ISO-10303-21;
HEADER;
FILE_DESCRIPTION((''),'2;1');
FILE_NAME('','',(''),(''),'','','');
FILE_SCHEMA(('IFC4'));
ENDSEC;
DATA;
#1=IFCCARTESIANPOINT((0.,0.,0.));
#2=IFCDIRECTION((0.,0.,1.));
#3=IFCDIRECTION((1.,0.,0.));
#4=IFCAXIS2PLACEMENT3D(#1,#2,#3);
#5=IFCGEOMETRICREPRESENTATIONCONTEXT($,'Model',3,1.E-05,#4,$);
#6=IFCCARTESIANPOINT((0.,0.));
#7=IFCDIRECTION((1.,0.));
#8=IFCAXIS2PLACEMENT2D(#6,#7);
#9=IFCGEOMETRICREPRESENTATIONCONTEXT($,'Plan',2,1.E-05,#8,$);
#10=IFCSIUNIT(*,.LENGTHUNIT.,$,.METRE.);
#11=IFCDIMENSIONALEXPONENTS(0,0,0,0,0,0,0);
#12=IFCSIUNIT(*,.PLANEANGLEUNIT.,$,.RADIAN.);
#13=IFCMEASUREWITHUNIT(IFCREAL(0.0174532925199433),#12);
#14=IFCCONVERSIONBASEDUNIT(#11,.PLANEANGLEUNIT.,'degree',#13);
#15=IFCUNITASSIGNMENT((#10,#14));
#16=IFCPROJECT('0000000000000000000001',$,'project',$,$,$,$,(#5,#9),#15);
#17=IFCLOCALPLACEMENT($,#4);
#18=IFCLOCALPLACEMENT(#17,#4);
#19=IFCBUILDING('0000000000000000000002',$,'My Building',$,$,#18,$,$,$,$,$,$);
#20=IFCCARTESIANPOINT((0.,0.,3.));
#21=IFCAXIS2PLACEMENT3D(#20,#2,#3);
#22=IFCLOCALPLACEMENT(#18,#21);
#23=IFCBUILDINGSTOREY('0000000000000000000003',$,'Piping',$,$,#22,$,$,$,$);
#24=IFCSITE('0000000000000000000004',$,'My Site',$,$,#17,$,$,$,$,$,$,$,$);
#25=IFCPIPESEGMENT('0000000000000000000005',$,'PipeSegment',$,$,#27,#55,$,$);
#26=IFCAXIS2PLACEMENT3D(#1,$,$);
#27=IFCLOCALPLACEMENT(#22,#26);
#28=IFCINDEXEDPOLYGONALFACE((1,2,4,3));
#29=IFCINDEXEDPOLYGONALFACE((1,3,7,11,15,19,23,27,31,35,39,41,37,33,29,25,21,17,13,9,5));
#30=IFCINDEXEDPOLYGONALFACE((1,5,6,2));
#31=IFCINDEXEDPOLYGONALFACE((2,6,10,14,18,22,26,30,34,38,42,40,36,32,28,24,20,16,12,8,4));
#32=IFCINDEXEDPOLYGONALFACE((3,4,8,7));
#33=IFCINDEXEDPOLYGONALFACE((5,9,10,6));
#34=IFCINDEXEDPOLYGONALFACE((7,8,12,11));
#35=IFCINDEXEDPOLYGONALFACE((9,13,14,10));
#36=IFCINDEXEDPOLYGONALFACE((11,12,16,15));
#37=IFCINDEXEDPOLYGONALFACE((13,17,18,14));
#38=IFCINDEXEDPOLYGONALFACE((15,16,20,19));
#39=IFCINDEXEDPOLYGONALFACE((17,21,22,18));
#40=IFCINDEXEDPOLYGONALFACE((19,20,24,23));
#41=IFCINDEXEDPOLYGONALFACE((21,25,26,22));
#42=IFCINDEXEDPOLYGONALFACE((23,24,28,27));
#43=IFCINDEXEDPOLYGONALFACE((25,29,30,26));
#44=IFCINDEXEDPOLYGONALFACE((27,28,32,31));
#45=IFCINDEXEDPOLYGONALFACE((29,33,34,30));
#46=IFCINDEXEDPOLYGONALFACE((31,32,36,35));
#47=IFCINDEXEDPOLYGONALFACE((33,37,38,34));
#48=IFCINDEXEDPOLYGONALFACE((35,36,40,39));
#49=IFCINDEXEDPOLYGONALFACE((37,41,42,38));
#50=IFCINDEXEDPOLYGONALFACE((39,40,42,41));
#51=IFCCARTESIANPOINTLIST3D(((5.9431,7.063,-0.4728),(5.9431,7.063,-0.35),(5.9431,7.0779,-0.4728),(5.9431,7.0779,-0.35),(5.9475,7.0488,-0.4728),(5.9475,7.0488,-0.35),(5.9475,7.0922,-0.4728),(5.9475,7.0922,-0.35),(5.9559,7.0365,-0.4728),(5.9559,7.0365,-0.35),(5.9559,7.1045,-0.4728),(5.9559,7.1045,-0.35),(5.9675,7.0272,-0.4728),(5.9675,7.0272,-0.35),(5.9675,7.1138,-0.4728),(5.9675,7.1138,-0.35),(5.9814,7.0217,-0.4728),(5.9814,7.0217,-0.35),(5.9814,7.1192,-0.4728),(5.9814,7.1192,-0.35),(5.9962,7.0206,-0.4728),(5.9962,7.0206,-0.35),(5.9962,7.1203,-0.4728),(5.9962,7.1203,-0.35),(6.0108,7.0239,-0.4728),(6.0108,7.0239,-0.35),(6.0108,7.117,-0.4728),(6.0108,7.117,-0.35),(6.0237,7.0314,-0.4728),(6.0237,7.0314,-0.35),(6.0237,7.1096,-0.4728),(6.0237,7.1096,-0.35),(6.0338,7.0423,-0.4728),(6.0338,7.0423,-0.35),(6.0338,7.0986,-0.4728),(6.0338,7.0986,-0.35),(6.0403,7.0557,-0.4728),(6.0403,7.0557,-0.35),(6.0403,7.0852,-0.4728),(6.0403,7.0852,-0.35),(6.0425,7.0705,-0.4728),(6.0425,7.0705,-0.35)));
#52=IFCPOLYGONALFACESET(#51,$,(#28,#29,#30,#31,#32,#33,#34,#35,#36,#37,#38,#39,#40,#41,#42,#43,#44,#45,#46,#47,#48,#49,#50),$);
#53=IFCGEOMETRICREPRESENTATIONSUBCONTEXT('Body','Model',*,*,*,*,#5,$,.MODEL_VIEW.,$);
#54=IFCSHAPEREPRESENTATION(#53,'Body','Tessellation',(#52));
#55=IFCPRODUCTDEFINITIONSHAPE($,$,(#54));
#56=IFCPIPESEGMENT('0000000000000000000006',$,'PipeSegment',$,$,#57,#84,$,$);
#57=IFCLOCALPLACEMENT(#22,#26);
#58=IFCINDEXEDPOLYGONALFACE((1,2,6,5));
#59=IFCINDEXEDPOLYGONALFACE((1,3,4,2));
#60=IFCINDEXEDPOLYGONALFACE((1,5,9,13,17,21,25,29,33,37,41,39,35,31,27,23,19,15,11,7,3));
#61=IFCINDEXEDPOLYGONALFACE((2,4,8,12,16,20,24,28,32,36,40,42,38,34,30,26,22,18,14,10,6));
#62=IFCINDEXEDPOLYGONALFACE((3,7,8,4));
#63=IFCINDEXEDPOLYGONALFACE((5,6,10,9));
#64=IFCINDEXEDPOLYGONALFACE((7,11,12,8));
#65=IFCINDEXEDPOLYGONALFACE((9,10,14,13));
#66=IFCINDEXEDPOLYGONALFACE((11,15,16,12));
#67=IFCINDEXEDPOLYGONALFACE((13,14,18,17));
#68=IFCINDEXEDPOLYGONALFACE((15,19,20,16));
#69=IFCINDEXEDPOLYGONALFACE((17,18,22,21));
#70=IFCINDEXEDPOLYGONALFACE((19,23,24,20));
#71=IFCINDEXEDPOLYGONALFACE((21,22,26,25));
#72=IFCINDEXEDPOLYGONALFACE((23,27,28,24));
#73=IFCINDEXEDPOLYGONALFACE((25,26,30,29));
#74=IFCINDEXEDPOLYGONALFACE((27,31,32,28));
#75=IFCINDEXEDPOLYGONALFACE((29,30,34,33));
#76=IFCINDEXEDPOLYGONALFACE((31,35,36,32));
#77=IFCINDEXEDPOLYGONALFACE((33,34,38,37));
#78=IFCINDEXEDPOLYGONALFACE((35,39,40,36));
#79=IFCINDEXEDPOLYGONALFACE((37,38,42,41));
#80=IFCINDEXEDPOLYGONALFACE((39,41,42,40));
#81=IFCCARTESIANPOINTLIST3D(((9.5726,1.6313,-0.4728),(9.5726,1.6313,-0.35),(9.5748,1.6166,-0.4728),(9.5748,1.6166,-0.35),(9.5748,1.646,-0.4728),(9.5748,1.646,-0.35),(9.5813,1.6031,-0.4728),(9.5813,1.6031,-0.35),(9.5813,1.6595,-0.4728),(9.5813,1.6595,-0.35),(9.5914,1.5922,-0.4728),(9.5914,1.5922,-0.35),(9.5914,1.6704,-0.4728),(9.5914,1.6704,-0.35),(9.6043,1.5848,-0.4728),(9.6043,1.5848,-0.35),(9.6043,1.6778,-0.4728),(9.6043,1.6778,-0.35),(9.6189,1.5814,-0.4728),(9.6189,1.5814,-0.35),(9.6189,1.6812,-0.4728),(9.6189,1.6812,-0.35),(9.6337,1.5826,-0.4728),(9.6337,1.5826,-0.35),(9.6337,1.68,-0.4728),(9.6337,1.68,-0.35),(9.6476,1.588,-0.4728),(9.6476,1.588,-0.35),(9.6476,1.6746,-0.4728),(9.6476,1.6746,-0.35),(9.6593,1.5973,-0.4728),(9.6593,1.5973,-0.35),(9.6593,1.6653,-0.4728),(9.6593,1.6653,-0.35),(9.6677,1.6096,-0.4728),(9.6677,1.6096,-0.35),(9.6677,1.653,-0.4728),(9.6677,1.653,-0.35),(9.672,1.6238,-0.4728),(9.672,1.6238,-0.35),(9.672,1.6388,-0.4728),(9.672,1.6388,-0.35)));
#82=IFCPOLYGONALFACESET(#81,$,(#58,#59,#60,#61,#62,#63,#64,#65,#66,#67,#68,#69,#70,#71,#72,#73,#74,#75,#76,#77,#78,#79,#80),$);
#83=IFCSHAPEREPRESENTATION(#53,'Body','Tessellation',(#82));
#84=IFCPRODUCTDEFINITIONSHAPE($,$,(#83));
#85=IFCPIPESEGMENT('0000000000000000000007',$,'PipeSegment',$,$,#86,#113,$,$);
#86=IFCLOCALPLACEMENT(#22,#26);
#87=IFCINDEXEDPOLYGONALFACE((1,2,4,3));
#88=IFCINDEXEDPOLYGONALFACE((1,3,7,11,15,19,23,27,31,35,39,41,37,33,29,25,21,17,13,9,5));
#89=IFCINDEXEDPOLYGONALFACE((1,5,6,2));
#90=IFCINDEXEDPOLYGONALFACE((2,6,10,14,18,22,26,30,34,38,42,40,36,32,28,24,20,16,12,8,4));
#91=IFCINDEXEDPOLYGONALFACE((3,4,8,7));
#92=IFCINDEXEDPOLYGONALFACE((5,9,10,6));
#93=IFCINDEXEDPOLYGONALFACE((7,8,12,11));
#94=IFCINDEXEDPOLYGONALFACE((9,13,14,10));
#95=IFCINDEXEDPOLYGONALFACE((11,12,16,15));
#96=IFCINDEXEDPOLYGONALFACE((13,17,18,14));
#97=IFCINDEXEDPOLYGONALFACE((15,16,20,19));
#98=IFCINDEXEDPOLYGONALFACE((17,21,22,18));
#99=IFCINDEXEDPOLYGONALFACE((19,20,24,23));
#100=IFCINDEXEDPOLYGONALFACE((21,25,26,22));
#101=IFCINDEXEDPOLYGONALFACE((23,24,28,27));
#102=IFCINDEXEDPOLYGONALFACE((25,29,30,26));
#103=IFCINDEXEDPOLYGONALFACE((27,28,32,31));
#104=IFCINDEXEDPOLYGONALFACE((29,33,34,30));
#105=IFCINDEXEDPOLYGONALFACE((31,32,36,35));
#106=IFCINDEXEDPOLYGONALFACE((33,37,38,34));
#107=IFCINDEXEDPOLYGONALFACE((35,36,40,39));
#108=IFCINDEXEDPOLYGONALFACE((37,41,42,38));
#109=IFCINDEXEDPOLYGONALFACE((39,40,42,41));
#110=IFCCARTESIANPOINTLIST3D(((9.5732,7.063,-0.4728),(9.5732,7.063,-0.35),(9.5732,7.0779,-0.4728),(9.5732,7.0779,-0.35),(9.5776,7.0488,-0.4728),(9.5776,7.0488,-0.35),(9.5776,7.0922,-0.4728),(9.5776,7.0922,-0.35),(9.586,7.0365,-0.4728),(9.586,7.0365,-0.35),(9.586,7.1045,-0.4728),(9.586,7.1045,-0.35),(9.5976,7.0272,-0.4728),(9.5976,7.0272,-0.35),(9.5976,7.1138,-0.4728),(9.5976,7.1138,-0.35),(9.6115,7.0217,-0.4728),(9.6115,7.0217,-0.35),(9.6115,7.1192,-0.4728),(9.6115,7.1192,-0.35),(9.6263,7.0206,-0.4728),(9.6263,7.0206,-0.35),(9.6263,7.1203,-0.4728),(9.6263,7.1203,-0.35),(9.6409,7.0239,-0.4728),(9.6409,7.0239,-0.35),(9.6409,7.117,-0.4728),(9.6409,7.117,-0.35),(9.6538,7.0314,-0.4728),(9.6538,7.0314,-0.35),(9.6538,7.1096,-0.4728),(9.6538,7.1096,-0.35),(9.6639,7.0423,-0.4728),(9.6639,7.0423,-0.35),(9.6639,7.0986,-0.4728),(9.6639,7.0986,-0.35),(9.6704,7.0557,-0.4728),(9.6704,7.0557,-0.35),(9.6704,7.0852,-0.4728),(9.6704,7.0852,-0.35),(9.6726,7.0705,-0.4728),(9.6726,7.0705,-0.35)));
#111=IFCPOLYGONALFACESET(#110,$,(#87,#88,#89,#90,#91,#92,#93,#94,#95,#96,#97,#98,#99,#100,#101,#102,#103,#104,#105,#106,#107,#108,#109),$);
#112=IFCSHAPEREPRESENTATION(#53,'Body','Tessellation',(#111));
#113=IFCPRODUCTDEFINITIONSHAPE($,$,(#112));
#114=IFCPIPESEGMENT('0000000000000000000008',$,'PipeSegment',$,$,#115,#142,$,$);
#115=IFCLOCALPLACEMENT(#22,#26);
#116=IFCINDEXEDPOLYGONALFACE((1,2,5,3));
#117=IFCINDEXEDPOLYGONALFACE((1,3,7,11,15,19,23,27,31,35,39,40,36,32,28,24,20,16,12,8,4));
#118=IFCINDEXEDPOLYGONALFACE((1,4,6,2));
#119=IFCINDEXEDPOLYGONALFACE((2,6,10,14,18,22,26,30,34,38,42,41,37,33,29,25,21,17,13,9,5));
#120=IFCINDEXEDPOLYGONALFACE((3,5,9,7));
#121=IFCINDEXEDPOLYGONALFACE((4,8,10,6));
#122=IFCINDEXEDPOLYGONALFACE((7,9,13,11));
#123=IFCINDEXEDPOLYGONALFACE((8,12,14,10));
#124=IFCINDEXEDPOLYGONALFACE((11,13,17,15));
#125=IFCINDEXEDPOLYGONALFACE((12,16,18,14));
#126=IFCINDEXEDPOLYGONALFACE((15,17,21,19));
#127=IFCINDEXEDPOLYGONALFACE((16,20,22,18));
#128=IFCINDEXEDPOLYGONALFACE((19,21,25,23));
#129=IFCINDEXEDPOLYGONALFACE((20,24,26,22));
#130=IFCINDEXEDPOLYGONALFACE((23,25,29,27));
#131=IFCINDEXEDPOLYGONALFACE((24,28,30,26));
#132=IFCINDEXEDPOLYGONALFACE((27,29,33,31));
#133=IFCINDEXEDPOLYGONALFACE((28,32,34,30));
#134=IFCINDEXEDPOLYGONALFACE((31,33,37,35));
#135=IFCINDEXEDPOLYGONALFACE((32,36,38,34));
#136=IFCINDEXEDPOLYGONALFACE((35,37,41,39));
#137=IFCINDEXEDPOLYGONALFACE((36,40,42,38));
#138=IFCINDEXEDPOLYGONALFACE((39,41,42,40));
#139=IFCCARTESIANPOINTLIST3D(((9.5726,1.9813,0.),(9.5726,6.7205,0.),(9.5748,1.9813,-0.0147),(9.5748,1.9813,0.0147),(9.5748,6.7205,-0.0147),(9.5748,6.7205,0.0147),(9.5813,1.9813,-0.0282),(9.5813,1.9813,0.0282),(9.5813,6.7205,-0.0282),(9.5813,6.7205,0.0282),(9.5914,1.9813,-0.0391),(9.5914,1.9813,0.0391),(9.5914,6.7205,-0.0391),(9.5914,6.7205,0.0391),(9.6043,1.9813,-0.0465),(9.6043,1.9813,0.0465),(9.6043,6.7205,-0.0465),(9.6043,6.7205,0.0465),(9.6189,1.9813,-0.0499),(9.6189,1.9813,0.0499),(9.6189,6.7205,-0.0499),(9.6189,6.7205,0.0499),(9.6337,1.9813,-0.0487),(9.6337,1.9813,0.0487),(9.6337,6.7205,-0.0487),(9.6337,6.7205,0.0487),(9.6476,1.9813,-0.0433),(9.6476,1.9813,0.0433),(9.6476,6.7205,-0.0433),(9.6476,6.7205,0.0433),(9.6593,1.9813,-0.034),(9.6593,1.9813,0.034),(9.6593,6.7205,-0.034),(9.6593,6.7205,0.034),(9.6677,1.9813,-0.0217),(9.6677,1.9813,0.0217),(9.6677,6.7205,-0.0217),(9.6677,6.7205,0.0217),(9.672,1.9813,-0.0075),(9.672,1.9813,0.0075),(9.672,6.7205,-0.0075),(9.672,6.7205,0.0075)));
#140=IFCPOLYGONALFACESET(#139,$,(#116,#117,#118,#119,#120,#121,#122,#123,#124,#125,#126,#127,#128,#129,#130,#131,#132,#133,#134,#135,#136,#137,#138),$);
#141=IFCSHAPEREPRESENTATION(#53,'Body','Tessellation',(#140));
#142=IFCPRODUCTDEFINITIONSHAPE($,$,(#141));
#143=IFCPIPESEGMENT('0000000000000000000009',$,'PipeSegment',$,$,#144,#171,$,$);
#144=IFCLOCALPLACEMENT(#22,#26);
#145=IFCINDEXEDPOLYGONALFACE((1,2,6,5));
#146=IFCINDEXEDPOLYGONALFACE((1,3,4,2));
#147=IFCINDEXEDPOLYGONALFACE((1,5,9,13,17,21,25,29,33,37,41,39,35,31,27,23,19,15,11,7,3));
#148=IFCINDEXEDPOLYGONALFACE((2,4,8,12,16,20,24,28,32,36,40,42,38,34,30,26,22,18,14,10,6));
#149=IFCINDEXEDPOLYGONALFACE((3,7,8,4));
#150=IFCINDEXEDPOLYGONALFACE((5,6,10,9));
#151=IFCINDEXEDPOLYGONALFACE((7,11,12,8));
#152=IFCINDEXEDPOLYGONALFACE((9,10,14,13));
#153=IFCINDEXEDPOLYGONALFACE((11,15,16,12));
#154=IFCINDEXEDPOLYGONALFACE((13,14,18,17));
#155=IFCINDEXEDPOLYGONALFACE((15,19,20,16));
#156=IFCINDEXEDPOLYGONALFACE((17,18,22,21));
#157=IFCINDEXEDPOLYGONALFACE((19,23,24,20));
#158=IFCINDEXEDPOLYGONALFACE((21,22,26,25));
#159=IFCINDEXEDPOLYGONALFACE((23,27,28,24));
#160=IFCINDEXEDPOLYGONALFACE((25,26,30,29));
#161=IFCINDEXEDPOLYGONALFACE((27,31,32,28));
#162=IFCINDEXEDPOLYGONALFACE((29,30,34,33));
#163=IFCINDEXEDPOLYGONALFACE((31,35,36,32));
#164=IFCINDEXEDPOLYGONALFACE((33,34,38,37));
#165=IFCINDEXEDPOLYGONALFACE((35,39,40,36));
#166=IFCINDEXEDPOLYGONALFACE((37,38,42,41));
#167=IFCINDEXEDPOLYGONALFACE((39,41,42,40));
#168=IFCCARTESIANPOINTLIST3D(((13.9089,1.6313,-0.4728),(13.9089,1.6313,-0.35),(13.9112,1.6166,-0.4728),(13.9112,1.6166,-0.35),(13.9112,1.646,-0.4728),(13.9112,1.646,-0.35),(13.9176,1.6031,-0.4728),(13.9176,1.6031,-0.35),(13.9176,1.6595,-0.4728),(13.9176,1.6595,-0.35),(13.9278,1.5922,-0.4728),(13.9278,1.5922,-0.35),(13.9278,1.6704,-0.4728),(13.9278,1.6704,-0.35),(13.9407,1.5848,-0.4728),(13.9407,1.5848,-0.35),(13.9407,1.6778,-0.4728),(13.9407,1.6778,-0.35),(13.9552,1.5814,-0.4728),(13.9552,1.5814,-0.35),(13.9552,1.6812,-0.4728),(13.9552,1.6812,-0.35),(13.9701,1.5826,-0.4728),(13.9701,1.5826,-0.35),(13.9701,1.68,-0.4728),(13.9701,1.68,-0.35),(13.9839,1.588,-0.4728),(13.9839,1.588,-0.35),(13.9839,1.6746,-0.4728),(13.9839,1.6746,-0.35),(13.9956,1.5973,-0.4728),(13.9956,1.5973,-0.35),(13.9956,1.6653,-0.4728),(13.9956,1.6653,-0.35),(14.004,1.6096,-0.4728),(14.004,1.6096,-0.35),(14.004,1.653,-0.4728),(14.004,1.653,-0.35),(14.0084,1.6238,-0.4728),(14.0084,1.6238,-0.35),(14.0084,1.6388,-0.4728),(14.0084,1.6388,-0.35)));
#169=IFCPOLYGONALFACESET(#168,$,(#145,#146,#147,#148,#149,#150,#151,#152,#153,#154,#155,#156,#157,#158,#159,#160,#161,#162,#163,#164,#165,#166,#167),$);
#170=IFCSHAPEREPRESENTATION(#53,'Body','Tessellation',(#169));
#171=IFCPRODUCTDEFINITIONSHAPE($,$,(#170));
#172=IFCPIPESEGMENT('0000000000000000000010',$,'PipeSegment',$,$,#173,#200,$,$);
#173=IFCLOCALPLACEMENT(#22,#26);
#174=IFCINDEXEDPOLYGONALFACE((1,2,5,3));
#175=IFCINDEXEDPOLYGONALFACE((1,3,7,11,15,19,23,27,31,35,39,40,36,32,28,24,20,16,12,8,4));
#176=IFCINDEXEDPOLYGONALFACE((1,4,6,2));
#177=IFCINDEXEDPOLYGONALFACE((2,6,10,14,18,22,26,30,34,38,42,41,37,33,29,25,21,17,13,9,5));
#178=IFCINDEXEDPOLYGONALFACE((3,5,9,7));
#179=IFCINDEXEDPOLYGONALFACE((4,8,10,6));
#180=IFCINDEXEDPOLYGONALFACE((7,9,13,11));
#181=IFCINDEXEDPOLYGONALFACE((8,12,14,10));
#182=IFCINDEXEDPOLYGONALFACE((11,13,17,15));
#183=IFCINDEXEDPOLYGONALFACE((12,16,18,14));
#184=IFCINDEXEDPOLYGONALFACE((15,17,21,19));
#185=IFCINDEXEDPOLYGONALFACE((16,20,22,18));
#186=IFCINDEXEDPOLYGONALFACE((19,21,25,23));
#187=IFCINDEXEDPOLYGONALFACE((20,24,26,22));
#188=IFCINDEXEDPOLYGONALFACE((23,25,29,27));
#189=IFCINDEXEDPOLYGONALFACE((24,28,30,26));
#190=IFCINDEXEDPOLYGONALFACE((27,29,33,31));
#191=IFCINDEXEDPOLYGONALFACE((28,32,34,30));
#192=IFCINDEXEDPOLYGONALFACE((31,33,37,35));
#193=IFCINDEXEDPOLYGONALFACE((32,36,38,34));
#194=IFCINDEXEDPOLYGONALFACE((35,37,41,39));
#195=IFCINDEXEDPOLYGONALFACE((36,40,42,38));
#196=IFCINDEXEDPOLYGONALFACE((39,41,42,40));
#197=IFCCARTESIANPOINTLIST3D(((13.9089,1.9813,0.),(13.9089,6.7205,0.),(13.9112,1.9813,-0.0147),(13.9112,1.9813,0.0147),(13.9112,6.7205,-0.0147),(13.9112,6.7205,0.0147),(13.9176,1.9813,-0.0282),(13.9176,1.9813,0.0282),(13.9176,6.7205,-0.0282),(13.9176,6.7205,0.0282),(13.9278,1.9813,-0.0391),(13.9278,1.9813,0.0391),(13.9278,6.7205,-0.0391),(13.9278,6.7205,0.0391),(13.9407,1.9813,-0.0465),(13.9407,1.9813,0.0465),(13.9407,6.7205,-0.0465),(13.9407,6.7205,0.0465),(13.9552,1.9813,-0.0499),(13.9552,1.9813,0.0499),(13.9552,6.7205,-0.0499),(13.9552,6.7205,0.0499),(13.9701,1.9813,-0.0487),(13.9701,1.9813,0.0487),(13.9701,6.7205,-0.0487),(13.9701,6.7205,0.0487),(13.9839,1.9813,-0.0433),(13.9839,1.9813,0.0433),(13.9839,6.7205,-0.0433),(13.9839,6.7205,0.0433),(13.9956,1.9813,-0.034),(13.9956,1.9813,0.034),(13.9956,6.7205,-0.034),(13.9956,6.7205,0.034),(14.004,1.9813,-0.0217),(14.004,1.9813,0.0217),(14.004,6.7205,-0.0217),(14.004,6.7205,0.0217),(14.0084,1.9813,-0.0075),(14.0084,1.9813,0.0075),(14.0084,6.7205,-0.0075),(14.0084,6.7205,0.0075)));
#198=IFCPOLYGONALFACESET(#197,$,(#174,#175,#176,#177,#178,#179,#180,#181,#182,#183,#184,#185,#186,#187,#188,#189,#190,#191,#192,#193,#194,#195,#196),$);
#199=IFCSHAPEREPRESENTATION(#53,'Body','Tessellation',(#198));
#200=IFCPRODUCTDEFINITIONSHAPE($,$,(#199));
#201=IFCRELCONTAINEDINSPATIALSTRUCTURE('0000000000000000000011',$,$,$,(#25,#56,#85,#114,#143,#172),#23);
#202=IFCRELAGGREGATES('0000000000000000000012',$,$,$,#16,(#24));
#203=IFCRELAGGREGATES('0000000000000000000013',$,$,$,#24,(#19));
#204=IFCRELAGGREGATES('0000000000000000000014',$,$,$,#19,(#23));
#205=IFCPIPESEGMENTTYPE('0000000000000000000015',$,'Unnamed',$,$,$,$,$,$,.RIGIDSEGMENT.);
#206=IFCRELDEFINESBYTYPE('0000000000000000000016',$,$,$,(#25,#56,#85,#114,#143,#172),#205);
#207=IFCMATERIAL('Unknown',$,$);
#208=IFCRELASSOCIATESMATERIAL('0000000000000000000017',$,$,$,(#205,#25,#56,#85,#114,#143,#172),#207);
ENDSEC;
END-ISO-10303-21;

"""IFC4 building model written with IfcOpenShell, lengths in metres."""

from ifc_helpers import new_model, entity, si_unit, converted_unit, frame, origin_with_axes, origin_2d_with_axis, place, context, subcontext, project, spatial, circle, extrude, material, material_profile, profile_set, profile_usage, type_object, element, save


model = new_model("IFC4")

# Units and contexts
model_context = context("Model", 3, precision=1e-05, world=origin_with_axes())
plan_context = context("Plan", 2, precision=1e-05, world=origin_2d_with_axis())
body_context = subcontext(model_context, "Body", "Model", "MODEL_VIEW")
ifc_project = project(units=[si_unit("LENGTHUNIT", "METRE"), converted_unit("PLANEANGLEUNIT", "degree", entity("IfcReal", 0.0174532925199433), si_unit("PLANEANGLEUNIT", "RADIAN"), dimensions=[0, 0, 0, 0, 0, 0, 0])], contexts=[model_context, plan_context])

# Site, building, storey
site_placement = place(None, origin_with_axes())
site = spatial("IfcSite", under=ifc_project, at=site_placement, Name="My Site")
building_placement = place(site_placement, origin_with_axes())
building = spatial("IfcBuilding", under=site, at=building_placement, Name="My Building")
storey_placement = place(building_placement, frame((0.0, 0.0, 3.0), z_axis=(0.0, 0.0, 1.0), x_axis=(1.0, 0.0, 0.0)))
storey = spatial("IfcBuildingStorey", under=building, at=storey_placement, Name="Piping")

# Pipe segments
ifc_material = material(Name="Unknown")
ifc_material_profile = material_profile(ifc_material, circle(Radius=0.05))
ifc_profile_set = profile_set([ifc_material_profile])
pipe_segment_type = type_object("IfcPipeSegmentType", Name="Unnamed", PredefinedType="RIGIDSEGMENT", material=ifc_profile_set)
ifc_profile_usage_1 = profile_usage(ifc_profile_set, cardinal=5)
pipe_segment_1_placement = place(storey_placement, frame((5.9925, 7.0705, -0.35), z_axis=(0.0, 0.0, -1.0), x_axis=(1.0, 0.0, 0.0)))
element("IfcPipeSegment", 1, at=pipe_segment_1_placement, inside=storey, type_object=pipe_segment_type, material=ifc_profile_usage_1, Name="PipeSegment", context=body_context, shape_type="SweptSolid", body=[
    extrude(circle(Radius=0.05), origin_with_axes(), (0.0, 0.0, 1.0), 0.1228),
])
ifc_profile_usage_2 = profile_usage(ifc_profile_set, cardinal=5)
pipe_segment_2_placement = place(storey_placement, frame((9.6226, 1.6313, -0.35), z_axis=(0.0, 0.0, -1.0), x_axis=(-1.0, 0.0, 0.0)))
element("IfcPipeSegment", 2, at=pipe_segment_2_placement, inside=storey, type_object=pipe_segment_type, material=ifc_profile_usage_2, Name="PipeSegment", context=body_context, shape_type="SweptSolid", body=[
    extrude(circle(Radius=0.05), origin_with_axes(), (0.0, 0.0, 1.0), 0.1228),
])
ifc_profile_usage_3 = profile_usage(ifc_profile_set, cardinal=5)
pipe_segment_3_placement = place(storey_placement, frame((9.6226, 7.0705, -0.35), z_axis=(0.0, 0.0, -1.0), x_axis=(1.0, 0.0, 0.0)))
element("IfcPipeSegment", 3, at=pipe_segment_3_placement, inside=storey, type_object=pipe_segment_type, material=ifc_profile_usage_3, Name="PipeSegment", context=body_context, shape_type="SweptSolid", body=[
    extrude(circle(Radius=0.05), origin_with_axes(), (0.0, 0.0, 1.0), 0.1228),
])
ifc_profile_usage_4 = profile_usage(ifc_profile_set, cardinal=5)
pipe_segment_4_placement = place(storey_placement, frame((9.6226, 1.9813, 0.0), z_axis=(0.0, 1.0, 0.0), x_axis=(-1.0, 0.0, 0.0)))
element("IfcPipeSegment", 4, at=pipe_segment_4_placement, inside=storey, type_object=pipe_segment_type, material=ifc_profile_usage_4, Name="PipeSegment", context=body_context, shape_type="SweptSolid", body=[
    extrude(circle(Radius=0.05), origin_with_axes(), (0.0, 0.0, 1.0), 4.7392),
])
ifc_profile_usage_5 = profile_usage(ifc_profile_set, cardinal=5)
pipe_segment_5_placement = place(storey_placement, frame((13.9589, 1.6313, -0.35), z_axis=(0.0, 0.0, -1.0), x_axis=(-1.0, 0.0, 0.0)))
element("IfcPipeSegment", 5, at=pipe_segment_5_placement, inside=storey, type_object=pipe_segment_type, material=ifc_profile_usage_5, Name="PipeSegment", context=body_context, shape_type="SweptSolid", body=[
    extrude(circle(Radius=0.05), origin_with_axes(), (0.0, 0.0, 1.0), 0.1228),
])
ifc_profile_usage_6 = profile_usage(ifc_profile_set, cardinal=5)
pipe_segment_6_placement = place(storey_placement, frame((13.9589, 1.9813, 0.0), z_axis=(0.0, 1.0, 0.0), x_axis=(-1.0, 0.0, 0.0)))
element("IfcPipeSegment", 6, at=pipe_segment_6_placement, inside=storey, type_object=pipe_segment_type, material=ifc_profile_usage_6, Name="PipeSegment", context=body_context, shape_type="SweptSolid", body=[
    extrude(circle(Radius=0.05), origin_with_axes(), (0.0, 0.0, 1.0), 4.7392),
])

save(model, "model.ifc")
